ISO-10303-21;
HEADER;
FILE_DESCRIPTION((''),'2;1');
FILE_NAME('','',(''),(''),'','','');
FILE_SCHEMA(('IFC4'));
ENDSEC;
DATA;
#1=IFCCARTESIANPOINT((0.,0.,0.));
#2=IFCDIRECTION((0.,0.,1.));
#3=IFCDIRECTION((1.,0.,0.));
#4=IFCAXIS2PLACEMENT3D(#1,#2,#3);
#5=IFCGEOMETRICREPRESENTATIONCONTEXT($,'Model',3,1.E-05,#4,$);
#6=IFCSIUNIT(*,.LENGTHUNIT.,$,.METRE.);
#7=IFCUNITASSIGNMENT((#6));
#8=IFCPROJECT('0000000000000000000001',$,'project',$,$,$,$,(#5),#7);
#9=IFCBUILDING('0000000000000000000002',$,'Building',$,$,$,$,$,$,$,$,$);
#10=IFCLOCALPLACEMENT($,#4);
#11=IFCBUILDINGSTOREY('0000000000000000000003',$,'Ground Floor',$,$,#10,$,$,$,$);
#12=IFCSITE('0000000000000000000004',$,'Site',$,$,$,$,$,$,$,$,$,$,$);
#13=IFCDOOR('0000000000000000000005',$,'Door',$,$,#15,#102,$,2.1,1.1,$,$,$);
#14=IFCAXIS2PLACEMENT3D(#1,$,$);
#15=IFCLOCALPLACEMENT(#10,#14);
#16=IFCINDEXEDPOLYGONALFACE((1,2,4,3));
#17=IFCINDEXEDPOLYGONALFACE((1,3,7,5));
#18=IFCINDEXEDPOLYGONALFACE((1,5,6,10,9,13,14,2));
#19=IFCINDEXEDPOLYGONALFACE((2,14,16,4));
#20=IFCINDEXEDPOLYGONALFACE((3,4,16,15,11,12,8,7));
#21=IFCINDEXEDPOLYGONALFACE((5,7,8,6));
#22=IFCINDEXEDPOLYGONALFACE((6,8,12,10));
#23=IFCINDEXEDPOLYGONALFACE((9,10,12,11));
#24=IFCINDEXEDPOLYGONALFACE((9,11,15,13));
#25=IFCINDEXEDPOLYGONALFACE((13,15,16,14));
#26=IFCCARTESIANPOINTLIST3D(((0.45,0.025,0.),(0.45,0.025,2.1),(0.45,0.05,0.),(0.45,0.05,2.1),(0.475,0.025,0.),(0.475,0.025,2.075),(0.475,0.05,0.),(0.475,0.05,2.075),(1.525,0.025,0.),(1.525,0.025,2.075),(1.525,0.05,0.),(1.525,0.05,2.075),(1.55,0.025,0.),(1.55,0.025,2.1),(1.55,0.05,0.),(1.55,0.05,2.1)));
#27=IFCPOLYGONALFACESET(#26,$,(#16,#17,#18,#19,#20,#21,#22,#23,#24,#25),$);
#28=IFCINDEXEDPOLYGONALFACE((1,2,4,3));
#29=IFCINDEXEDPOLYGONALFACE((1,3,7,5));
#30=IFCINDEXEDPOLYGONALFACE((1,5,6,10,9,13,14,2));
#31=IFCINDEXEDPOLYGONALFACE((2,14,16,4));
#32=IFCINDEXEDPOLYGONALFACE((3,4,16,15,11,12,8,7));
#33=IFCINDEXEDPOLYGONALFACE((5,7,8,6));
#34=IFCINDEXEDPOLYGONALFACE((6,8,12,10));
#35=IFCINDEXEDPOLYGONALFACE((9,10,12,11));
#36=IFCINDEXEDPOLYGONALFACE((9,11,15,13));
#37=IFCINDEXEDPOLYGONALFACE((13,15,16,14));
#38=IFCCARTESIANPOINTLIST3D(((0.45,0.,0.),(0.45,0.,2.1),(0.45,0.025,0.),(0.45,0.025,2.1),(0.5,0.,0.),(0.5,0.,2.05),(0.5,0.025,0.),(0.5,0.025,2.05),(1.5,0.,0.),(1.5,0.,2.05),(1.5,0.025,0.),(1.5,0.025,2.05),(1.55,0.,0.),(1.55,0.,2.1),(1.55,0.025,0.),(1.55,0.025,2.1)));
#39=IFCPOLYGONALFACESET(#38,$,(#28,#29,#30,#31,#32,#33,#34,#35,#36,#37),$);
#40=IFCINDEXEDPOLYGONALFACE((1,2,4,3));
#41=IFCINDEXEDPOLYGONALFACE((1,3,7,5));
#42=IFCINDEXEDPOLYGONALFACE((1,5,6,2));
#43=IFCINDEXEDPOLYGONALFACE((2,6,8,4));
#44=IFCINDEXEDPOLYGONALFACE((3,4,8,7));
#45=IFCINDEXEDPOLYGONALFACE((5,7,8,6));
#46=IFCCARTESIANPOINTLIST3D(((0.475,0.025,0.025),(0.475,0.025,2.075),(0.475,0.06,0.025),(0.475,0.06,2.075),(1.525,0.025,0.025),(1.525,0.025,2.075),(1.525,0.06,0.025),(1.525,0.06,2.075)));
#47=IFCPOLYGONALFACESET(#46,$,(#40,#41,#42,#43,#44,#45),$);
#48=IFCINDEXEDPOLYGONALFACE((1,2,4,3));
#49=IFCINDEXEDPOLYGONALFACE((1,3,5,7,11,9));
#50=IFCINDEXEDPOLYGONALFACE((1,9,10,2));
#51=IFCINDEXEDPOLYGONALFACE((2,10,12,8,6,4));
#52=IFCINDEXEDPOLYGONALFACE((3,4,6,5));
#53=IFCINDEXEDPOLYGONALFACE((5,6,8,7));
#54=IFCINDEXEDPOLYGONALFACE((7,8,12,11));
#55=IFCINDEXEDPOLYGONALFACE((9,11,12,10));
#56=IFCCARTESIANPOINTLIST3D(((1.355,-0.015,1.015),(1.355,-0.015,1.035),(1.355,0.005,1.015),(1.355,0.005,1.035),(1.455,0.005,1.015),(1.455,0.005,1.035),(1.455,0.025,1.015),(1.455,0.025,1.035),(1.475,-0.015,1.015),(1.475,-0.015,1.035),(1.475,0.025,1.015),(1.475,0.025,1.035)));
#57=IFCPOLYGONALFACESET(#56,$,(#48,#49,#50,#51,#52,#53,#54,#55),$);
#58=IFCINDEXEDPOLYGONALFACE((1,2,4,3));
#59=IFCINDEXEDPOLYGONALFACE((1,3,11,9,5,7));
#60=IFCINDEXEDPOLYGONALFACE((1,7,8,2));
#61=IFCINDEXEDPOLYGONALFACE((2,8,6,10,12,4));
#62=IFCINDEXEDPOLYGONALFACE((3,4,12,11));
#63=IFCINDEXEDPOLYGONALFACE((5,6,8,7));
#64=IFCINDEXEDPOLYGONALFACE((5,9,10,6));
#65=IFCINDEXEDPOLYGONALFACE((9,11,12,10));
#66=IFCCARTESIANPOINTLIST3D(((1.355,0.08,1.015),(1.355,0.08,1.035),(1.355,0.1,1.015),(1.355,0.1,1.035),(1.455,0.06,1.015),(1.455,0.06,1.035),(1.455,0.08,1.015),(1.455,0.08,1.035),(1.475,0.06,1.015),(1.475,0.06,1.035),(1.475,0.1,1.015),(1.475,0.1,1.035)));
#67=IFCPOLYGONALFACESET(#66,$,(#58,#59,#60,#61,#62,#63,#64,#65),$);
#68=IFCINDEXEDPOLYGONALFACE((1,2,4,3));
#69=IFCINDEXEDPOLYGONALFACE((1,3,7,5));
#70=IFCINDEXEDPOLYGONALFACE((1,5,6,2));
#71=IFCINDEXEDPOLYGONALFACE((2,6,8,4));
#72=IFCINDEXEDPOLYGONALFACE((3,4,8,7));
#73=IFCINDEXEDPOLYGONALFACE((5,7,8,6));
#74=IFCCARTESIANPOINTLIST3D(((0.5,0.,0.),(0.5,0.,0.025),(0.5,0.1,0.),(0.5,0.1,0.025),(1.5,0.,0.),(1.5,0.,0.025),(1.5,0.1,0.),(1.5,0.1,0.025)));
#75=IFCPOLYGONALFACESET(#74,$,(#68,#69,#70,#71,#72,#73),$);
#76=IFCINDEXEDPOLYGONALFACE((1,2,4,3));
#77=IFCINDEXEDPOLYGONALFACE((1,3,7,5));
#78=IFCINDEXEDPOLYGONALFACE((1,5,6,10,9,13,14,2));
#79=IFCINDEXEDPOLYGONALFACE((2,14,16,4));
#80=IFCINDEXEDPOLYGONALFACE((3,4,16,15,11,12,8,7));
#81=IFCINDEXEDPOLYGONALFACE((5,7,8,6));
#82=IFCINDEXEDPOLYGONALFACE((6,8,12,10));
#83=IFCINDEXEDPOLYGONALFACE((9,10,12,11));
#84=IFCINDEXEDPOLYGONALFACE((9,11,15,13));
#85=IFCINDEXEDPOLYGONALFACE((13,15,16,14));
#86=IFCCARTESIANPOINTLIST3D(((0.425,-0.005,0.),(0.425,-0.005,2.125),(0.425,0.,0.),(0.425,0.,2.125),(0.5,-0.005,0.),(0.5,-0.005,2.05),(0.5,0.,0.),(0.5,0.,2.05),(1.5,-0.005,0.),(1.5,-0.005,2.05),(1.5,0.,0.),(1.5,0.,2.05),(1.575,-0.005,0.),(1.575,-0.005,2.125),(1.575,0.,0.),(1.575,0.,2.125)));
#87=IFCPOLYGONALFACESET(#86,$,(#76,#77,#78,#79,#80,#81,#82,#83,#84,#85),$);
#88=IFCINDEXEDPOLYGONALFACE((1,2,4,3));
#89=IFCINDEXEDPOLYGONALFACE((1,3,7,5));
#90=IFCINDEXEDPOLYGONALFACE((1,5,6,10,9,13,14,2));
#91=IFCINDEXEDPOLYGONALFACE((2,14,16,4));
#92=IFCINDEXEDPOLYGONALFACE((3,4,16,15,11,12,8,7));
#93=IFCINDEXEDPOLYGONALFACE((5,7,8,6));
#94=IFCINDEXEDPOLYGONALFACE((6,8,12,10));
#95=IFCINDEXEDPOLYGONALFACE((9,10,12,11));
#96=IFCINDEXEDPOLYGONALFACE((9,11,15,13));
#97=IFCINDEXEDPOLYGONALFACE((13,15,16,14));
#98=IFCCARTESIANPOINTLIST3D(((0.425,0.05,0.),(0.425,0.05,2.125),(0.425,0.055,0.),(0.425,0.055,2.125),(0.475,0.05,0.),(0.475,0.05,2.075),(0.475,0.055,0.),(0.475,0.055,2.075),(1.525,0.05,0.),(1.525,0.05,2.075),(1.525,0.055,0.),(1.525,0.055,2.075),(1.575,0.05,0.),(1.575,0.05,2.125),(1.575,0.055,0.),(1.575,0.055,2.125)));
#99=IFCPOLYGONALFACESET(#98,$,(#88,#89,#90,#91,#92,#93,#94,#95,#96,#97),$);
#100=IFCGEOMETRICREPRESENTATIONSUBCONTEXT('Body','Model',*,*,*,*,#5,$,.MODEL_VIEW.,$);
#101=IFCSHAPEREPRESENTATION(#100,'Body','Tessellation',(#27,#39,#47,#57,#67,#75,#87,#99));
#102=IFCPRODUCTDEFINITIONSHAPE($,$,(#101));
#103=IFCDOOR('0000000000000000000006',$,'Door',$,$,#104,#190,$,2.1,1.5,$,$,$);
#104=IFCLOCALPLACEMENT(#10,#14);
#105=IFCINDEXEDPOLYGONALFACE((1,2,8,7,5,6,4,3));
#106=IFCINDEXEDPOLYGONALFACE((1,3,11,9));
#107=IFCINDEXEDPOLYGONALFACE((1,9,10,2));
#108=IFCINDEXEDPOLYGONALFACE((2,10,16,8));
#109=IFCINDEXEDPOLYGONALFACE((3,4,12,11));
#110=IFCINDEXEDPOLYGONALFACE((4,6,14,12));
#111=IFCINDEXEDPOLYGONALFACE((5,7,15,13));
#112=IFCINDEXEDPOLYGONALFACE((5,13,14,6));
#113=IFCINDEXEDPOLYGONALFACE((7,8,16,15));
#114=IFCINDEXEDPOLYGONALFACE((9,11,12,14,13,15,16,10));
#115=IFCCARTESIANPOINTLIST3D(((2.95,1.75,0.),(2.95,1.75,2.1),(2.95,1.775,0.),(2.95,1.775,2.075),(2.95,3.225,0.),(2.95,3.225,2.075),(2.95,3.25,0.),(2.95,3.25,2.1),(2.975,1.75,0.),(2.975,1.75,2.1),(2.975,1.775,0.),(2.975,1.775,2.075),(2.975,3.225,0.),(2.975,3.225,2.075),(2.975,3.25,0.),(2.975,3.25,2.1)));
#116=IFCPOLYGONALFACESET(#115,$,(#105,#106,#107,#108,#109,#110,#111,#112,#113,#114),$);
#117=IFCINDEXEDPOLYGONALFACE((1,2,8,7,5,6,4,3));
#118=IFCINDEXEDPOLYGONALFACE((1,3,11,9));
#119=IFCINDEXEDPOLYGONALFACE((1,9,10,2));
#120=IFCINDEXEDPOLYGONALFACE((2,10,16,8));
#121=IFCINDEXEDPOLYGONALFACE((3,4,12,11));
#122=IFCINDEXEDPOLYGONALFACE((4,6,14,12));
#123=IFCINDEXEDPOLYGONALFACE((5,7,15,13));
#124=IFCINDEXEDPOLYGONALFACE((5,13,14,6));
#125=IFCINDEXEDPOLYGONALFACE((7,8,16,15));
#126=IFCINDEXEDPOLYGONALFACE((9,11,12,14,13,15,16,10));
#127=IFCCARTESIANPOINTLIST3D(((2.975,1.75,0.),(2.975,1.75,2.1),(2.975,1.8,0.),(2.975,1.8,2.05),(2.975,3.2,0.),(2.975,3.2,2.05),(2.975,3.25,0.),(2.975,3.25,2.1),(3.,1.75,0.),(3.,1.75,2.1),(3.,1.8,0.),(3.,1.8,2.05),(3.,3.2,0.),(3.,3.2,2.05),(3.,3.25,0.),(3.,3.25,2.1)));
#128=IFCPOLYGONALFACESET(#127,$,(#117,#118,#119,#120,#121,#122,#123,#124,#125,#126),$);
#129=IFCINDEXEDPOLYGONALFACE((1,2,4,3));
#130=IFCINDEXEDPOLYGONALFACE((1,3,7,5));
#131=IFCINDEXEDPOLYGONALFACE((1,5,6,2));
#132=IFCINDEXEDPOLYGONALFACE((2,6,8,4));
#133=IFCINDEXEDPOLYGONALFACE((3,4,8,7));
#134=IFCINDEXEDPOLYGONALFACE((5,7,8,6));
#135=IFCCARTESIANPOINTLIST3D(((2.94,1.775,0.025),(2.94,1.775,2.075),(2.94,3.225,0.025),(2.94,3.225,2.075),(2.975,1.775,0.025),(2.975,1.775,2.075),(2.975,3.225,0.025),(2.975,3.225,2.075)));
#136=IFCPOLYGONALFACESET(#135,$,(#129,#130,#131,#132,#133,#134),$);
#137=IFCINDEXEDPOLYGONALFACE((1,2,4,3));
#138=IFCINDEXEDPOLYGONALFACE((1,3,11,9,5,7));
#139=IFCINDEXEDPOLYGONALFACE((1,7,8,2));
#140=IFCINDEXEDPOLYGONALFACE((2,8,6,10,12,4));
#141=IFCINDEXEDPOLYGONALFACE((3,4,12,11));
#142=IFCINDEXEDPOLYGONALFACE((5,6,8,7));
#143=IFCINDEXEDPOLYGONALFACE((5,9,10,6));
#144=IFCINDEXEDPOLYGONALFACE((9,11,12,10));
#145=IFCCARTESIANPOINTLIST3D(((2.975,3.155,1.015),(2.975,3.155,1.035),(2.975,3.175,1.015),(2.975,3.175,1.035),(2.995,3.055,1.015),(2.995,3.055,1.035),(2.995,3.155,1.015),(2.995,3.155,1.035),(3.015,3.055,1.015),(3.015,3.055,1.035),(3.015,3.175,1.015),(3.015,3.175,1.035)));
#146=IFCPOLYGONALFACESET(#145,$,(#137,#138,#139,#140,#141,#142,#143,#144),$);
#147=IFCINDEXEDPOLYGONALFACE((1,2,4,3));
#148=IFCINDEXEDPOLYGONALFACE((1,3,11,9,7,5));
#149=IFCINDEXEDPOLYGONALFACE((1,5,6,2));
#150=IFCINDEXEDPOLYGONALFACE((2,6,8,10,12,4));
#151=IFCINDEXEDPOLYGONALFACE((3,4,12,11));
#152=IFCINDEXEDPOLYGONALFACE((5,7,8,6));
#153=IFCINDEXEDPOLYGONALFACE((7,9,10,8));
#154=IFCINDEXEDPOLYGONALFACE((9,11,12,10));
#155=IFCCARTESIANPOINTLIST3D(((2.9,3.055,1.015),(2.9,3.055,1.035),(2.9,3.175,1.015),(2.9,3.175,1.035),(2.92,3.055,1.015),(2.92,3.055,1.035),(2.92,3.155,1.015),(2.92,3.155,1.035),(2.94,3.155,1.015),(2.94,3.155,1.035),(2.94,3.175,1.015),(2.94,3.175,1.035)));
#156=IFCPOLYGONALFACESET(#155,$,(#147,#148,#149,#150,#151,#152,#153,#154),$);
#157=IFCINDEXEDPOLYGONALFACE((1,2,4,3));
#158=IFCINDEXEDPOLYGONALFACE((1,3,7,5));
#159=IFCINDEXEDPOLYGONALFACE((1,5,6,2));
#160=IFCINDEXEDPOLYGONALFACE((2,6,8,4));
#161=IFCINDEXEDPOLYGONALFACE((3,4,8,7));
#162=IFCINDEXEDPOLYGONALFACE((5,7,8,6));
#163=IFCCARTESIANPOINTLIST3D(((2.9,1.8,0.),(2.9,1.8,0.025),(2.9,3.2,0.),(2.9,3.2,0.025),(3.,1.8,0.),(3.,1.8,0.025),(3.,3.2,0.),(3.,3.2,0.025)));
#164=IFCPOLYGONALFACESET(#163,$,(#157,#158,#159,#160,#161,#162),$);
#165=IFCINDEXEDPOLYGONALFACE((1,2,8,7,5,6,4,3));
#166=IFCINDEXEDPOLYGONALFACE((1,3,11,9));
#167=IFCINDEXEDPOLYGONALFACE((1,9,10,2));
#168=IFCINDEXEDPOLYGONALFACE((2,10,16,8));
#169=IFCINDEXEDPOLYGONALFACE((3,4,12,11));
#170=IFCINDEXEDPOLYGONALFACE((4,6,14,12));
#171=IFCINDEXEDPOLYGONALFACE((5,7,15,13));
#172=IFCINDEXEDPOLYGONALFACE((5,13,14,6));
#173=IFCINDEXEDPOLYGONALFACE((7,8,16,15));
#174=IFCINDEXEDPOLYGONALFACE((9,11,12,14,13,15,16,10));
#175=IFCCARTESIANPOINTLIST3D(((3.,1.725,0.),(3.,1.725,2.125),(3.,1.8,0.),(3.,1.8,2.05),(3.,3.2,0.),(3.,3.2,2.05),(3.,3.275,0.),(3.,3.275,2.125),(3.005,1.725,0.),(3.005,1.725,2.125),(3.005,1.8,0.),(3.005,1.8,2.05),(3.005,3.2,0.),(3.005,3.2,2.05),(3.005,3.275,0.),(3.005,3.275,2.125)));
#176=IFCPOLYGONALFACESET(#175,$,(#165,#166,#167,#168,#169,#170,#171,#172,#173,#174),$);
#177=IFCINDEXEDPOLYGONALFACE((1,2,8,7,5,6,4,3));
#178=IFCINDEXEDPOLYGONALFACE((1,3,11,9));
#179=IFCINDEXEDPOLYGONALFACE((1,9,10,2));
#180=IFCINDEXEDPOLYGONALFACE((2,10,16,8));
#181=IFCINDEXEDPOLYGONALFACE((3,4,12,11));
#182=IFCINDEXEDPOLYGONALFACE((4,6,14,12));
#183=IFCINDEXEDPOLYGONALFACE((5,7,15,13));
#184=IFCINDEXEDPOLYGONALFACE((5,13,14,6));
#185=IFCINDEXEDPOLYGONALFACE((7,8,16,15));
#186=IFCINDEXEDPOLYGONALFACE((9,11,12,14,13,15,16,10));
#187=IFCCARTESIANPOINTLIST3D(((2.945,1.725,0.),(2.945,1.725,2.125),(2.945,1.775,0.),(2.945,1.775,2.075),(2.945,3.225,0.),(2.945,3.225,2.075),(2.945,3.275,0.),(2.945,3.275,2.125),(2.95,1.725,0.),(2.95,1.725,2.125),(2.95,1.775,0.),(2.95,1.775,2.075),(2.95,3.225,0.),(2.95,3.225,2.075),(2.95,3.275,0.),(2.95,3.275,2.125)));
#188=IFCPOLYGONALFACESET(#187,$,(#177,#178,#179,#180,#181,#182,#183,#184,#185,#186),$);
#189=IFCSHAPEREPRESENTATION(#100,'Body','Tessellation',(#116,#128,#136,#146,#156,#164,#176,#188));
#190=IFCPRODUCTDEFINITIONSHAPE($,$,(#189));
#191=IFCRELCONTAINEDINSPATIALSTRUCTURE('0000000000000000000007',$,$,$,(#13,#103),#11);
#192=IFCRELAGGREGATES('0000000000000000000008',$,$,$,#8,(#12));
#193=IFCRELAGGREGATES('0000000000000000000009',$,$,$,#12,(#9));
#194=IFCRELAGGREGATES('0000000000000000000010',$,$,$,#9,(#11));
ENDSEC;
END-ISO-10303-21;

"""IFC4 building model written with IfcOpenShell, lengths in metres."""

from ifc_helpers import new_model, si_unit, frame, origin_with_axes, place, context, subcontext, project, spatial, line, indexed_curve, outline, extrude, element, save


model = new_model("IFC4")

# Units and contexts
model_context = context("Model", 3, precision=1e-05, world=origin_with_axes())
body_context = subcontext(model_context, "Body", "Model", "MODEL_VIEW")
ifc_project = project(units=[si_unit("LENGTHUNIT", "METRE")], contexts=[model_context])

# Site, building, storey
site = spatial("IfcSite", under=ifc_project, Name="Site")
building = spatial("IfcBuilding", under=site, Name="Building")
storey_placement = place(None, origin_with_axes())
storey = spatial("IfcBuildingStorey", under=building, at=storey_placement, Name="Ground Floor")

# Doors
door_1_placement = place(storey_placement, frame((0.45, 0.0, 0.0), z_axis=(0.0, 0.0, 1.0), x_axis=(1.0, 0.0, 0.0)))
element("IfcDoor", 1, at=door_1_placement, inside=storey, Name="Door", OverallHeight=2.1, OverallWidth=1.1, context=body_context, shape_type="SweptSolid", body=[
    extrude(outline(indexed_curve([(0.0, 0.0), (0.0, 2.1), (1.1, 2.1), (1.1, 0.0), (1.075, 0.0), (1.075, 2.075), (0.025, 2.075), (0.025, 0.0)], segments=[line(1, 2, 3, 4, 5, 6, 7, 8, 1)])), frame((0.0, 0.025, 0.0), z_axis=(0.0, -1.0, 0.0), x_axis=(1.0, 0.0, 0.0)), (0.0, 0.0, -1.0), 0.025),
    extrude(outline(indexed_curve([(0.0, 0.0), (0.0, 2.1), (1.1, 2.1), (1.1, 0.0), (1.05, 0.0), (1.05, 2.05), (0.05, 2.05), (0.05, 0.0)], segments=[line(1, 2, 3, 4, 5, 6, 7, 8, 1)])), frame((0.0, 0.0, 0.0), z_axis=(0.0, -1.0, 0.0), x_axis=(1.0, 0.0, 0.0)), (0.0, 0.0, -1.0), 0.025),
    extrude(outline(indexed_curve([(0.0, 0.0), (1.05, 0.0), (1.05, 0.035), (0.0, 0.035)], segments=[line(1, 2, 3, 4, 1)])), frame((0.025, 0.025, 0.025), z_axis=(0.0, 0.0, 1.0), x_axis=(1.0, 0.0, 0.0)), (0.0, 0.0, 1.0), 2.05),
    extrude(outline(indexed_curve([(0.0, 0.0), (0.0, -0.04), (-0.12, -0.04), (-0.12, -0.02), (-0.02, -0.02), (-0.02, 0.0)], segments=[line(1, 2, 3, 4, 5, 6, 1)])), frame((1.025, 0.025, 1.015), z_axis=(0.0, 0.0, 1.0), x_axis=(1.0, 0.0, 0.0)), (0.0, 0.0, 1.0), 0.02),
    extrude(outline(indexed_curve([(0.0, 0.0), (0.0, 0.04), (-0.12, 0.04), (-0.12, 0.02), (-0.02, 0.02), (-0.02, 0.0)], segments=[line(1, 2, 3, 4, 5, 6, 1)])), frame((1.025, 0.06, 1.015), z_axis=(0.0, 0.0, 1.0), x_axis=(1.0, 0.0, 0.0)), (0.0, 0.0, 1.0), 0.02),
    extrude(outline(indexed_curve([(0.0, 0.0), (1.0, 0.0), (1.0, 0.1), (0.0, 0.1)], segments=[line(1, 2, 3, 4, 1)])), frame((0.05, 0.0, 0.0), z_axis=(0.0, 0.0, 1.0), x_axis=(1.0, 0.0, 0.0)), (0.0, 0.0, 1.0), 0.025),
    extrude(outline(indexed_curve([(0.0, 0.0), (0.0, 2.125), (1.15, 2.125), (1.15, 0.0), (1.075, 0.0), (1.075, 2.05), (0.075, 2.05), (0.075, 0.0)], segments=[line(1, 2, 3, 4, 5, 6, 7, 8, 1)])), frame((-0.025, -0.005, 0.0), z_axis=(0.0, -1.0, 0.0), x_axis=(1.0, 0.0, 0.0)), (0.0, 0.0, -1.0), 0.005),
    extrude(outline(indexed_curve([(0.0, 0.0), (0.0, 2.125), (1.15, 2.125), (1.15, 0.0), (1.1, 0.0), (1.1, 2.075), (0.05, 2.075), (0.05, 0.0)], segments=[line(1, 2, 3, 4, 5, 6, 7, 8, 1)])), frame((-0.025, 0.05, 0.0), z_axis=(0.0, -1.0, 0.0), x_axis=(1.0, 0.0, 0.0)), (0.0, 0.0, -1.0), 0.005),
])
door_2_placement = place(storey_placement, frame((3.0, 1.75, 0.0), z_axis=(0.0, 0.0, 1.0), x_axis=(0.0, 1.0, 0.0)))
element("IfcDoor", 2, at=door_2_placement, inside=storey, Name="Door", OverallHeight=2.1, OverallWidth=1.5, context=body_context, shape_type="SweptSolid", body=[
    extrude(outline(indexed_curve([(0.0, 0.0), (0.0, 2.1), (1.5, 2.1), (1.5, 0.0), (1.475, 0.0), (1.475, 2.075), (0.025, 2.075), (0.025, 0.0)], segments=[line(1, 2, 3, 4, 5, 6, 7, 8, 1)])), frame((0.0, 0.025, 0.0), z_axis=(0.0, -1.0, 0.0), x_axis=(1.0, 0.0, 0.0)), (0.0, 0.0, -1.0), 0.025),
    extrude(outline(indexed_curve([(0.0, 0.0), (0.0, 2.1), (1.5, 2.1), (1.5, 0.0), (1.45, 0.0), (1.45, 2.05), (0.05, 2.05), (0.05, 0.0)], segments=[line(1, 2, 3, 4, 5, 6, 7, 8, 1)])), frame((0.0, 0.0, 0.0), z_axis=(0.0, -1.0, 0.0), x_axis=(1.0, 0.0, 0.0)), (0.0, 0.0, -1.0), 0.025),
    extrude(outline(indexed_curve([(0.0, 0.0), (1.45, 0.0), (1.45, 0.035), (0.0, 0.035)], segments=[line(1, 2, 3, 4, 1)])), frame((0.025, 0.025, 0.025), z_axis=(0.0, 0.0, 1.0), x_axis=(1.0, 0.0, 0.0)), (0.0, 0.0, 1.0), 2.05),
    extrude(outline(indexed_curve([(0.0, 0.0), (0.0, -0.04), (-0.12, -0.04), (-0.12, -0.02), (-0.02, -0.02), (-0.02, 0.0)], segments=[line(1, 2, 3, 4, 5, 6, 1)])), frame((1.425, 0.025, 1.015), z_axis=(0.0, 0.0, 1.0), x_axis=(1.0, 0.0, 0.0)), (0.0, 0.0, 1.0), 0.02),
    extrude(outline(indexed_curve([(0.0, 0.0), (0.0, 0.04), (-0.12, 0.04), (-0.12, 0.02), (-0.02, 0.02), (-0.02, 0.0)], segments=[line(1, 2, 3, 4, 5, 6, 1)])), frame((1.425, 0.06, 1.015), z_axis=(0.0, 0.0, 1.0), x_axis=(1.0, 0.0, 0.0)), (0.0, 0.0, 1.0), 0.02),
    extrude(outline(indexed_curve([(0.0, 0.0), (1.4, 0.0), (1.4, 0.1), (0.0, 0.1)], segments=[line(1, 2, 3, 4, 1)])), frame((0.05, 0.0, 0.0), z_axis=(0.0, 0.0, 1.0), x_axis=(1.0, 0.0, 0.0)), (0.0, 0.0, 1.0), 0.025),
    extrude(outline(indexed_curve([(0.0, 0.0), (0.0, 2.125), (1.55, 2.125), (1.55, 0.0), (1.475, 0.0), (1.475, 2.05), (0.075, 2.05), (0.075, 0.0)], segments=[line(1, 2, 3, 4, 5, 6, 7, 8, 1)])), frame((-0.025, -0.005, 0.0), z_axis=(0.0, -1.0, 0.0), x_axis=(1.0, 0.0, 0.0)), (0.0, 0.0, -1.0), 0.005),
    extrude(outline(indexed_curve([(0.0, 0.0), (0.0, 2.125), (1.55, 2.125), (1.55, 0.0), (1.5, 0.0), (1.5, 2.075), (0.05, 2.075), (0.05, 0.0)], segments=[line(1, 2, 3, 4, 5, 6, 7, 8, 1)])), frame((-0.025, 0.05, 0.0), z_axis=(0.0, -1.0, 0.0), x_axis=(1.0, 0.0, 0.0)), (0.0, 0.0, -1.0), 0.005),
])

save(model, "model.ifc")
